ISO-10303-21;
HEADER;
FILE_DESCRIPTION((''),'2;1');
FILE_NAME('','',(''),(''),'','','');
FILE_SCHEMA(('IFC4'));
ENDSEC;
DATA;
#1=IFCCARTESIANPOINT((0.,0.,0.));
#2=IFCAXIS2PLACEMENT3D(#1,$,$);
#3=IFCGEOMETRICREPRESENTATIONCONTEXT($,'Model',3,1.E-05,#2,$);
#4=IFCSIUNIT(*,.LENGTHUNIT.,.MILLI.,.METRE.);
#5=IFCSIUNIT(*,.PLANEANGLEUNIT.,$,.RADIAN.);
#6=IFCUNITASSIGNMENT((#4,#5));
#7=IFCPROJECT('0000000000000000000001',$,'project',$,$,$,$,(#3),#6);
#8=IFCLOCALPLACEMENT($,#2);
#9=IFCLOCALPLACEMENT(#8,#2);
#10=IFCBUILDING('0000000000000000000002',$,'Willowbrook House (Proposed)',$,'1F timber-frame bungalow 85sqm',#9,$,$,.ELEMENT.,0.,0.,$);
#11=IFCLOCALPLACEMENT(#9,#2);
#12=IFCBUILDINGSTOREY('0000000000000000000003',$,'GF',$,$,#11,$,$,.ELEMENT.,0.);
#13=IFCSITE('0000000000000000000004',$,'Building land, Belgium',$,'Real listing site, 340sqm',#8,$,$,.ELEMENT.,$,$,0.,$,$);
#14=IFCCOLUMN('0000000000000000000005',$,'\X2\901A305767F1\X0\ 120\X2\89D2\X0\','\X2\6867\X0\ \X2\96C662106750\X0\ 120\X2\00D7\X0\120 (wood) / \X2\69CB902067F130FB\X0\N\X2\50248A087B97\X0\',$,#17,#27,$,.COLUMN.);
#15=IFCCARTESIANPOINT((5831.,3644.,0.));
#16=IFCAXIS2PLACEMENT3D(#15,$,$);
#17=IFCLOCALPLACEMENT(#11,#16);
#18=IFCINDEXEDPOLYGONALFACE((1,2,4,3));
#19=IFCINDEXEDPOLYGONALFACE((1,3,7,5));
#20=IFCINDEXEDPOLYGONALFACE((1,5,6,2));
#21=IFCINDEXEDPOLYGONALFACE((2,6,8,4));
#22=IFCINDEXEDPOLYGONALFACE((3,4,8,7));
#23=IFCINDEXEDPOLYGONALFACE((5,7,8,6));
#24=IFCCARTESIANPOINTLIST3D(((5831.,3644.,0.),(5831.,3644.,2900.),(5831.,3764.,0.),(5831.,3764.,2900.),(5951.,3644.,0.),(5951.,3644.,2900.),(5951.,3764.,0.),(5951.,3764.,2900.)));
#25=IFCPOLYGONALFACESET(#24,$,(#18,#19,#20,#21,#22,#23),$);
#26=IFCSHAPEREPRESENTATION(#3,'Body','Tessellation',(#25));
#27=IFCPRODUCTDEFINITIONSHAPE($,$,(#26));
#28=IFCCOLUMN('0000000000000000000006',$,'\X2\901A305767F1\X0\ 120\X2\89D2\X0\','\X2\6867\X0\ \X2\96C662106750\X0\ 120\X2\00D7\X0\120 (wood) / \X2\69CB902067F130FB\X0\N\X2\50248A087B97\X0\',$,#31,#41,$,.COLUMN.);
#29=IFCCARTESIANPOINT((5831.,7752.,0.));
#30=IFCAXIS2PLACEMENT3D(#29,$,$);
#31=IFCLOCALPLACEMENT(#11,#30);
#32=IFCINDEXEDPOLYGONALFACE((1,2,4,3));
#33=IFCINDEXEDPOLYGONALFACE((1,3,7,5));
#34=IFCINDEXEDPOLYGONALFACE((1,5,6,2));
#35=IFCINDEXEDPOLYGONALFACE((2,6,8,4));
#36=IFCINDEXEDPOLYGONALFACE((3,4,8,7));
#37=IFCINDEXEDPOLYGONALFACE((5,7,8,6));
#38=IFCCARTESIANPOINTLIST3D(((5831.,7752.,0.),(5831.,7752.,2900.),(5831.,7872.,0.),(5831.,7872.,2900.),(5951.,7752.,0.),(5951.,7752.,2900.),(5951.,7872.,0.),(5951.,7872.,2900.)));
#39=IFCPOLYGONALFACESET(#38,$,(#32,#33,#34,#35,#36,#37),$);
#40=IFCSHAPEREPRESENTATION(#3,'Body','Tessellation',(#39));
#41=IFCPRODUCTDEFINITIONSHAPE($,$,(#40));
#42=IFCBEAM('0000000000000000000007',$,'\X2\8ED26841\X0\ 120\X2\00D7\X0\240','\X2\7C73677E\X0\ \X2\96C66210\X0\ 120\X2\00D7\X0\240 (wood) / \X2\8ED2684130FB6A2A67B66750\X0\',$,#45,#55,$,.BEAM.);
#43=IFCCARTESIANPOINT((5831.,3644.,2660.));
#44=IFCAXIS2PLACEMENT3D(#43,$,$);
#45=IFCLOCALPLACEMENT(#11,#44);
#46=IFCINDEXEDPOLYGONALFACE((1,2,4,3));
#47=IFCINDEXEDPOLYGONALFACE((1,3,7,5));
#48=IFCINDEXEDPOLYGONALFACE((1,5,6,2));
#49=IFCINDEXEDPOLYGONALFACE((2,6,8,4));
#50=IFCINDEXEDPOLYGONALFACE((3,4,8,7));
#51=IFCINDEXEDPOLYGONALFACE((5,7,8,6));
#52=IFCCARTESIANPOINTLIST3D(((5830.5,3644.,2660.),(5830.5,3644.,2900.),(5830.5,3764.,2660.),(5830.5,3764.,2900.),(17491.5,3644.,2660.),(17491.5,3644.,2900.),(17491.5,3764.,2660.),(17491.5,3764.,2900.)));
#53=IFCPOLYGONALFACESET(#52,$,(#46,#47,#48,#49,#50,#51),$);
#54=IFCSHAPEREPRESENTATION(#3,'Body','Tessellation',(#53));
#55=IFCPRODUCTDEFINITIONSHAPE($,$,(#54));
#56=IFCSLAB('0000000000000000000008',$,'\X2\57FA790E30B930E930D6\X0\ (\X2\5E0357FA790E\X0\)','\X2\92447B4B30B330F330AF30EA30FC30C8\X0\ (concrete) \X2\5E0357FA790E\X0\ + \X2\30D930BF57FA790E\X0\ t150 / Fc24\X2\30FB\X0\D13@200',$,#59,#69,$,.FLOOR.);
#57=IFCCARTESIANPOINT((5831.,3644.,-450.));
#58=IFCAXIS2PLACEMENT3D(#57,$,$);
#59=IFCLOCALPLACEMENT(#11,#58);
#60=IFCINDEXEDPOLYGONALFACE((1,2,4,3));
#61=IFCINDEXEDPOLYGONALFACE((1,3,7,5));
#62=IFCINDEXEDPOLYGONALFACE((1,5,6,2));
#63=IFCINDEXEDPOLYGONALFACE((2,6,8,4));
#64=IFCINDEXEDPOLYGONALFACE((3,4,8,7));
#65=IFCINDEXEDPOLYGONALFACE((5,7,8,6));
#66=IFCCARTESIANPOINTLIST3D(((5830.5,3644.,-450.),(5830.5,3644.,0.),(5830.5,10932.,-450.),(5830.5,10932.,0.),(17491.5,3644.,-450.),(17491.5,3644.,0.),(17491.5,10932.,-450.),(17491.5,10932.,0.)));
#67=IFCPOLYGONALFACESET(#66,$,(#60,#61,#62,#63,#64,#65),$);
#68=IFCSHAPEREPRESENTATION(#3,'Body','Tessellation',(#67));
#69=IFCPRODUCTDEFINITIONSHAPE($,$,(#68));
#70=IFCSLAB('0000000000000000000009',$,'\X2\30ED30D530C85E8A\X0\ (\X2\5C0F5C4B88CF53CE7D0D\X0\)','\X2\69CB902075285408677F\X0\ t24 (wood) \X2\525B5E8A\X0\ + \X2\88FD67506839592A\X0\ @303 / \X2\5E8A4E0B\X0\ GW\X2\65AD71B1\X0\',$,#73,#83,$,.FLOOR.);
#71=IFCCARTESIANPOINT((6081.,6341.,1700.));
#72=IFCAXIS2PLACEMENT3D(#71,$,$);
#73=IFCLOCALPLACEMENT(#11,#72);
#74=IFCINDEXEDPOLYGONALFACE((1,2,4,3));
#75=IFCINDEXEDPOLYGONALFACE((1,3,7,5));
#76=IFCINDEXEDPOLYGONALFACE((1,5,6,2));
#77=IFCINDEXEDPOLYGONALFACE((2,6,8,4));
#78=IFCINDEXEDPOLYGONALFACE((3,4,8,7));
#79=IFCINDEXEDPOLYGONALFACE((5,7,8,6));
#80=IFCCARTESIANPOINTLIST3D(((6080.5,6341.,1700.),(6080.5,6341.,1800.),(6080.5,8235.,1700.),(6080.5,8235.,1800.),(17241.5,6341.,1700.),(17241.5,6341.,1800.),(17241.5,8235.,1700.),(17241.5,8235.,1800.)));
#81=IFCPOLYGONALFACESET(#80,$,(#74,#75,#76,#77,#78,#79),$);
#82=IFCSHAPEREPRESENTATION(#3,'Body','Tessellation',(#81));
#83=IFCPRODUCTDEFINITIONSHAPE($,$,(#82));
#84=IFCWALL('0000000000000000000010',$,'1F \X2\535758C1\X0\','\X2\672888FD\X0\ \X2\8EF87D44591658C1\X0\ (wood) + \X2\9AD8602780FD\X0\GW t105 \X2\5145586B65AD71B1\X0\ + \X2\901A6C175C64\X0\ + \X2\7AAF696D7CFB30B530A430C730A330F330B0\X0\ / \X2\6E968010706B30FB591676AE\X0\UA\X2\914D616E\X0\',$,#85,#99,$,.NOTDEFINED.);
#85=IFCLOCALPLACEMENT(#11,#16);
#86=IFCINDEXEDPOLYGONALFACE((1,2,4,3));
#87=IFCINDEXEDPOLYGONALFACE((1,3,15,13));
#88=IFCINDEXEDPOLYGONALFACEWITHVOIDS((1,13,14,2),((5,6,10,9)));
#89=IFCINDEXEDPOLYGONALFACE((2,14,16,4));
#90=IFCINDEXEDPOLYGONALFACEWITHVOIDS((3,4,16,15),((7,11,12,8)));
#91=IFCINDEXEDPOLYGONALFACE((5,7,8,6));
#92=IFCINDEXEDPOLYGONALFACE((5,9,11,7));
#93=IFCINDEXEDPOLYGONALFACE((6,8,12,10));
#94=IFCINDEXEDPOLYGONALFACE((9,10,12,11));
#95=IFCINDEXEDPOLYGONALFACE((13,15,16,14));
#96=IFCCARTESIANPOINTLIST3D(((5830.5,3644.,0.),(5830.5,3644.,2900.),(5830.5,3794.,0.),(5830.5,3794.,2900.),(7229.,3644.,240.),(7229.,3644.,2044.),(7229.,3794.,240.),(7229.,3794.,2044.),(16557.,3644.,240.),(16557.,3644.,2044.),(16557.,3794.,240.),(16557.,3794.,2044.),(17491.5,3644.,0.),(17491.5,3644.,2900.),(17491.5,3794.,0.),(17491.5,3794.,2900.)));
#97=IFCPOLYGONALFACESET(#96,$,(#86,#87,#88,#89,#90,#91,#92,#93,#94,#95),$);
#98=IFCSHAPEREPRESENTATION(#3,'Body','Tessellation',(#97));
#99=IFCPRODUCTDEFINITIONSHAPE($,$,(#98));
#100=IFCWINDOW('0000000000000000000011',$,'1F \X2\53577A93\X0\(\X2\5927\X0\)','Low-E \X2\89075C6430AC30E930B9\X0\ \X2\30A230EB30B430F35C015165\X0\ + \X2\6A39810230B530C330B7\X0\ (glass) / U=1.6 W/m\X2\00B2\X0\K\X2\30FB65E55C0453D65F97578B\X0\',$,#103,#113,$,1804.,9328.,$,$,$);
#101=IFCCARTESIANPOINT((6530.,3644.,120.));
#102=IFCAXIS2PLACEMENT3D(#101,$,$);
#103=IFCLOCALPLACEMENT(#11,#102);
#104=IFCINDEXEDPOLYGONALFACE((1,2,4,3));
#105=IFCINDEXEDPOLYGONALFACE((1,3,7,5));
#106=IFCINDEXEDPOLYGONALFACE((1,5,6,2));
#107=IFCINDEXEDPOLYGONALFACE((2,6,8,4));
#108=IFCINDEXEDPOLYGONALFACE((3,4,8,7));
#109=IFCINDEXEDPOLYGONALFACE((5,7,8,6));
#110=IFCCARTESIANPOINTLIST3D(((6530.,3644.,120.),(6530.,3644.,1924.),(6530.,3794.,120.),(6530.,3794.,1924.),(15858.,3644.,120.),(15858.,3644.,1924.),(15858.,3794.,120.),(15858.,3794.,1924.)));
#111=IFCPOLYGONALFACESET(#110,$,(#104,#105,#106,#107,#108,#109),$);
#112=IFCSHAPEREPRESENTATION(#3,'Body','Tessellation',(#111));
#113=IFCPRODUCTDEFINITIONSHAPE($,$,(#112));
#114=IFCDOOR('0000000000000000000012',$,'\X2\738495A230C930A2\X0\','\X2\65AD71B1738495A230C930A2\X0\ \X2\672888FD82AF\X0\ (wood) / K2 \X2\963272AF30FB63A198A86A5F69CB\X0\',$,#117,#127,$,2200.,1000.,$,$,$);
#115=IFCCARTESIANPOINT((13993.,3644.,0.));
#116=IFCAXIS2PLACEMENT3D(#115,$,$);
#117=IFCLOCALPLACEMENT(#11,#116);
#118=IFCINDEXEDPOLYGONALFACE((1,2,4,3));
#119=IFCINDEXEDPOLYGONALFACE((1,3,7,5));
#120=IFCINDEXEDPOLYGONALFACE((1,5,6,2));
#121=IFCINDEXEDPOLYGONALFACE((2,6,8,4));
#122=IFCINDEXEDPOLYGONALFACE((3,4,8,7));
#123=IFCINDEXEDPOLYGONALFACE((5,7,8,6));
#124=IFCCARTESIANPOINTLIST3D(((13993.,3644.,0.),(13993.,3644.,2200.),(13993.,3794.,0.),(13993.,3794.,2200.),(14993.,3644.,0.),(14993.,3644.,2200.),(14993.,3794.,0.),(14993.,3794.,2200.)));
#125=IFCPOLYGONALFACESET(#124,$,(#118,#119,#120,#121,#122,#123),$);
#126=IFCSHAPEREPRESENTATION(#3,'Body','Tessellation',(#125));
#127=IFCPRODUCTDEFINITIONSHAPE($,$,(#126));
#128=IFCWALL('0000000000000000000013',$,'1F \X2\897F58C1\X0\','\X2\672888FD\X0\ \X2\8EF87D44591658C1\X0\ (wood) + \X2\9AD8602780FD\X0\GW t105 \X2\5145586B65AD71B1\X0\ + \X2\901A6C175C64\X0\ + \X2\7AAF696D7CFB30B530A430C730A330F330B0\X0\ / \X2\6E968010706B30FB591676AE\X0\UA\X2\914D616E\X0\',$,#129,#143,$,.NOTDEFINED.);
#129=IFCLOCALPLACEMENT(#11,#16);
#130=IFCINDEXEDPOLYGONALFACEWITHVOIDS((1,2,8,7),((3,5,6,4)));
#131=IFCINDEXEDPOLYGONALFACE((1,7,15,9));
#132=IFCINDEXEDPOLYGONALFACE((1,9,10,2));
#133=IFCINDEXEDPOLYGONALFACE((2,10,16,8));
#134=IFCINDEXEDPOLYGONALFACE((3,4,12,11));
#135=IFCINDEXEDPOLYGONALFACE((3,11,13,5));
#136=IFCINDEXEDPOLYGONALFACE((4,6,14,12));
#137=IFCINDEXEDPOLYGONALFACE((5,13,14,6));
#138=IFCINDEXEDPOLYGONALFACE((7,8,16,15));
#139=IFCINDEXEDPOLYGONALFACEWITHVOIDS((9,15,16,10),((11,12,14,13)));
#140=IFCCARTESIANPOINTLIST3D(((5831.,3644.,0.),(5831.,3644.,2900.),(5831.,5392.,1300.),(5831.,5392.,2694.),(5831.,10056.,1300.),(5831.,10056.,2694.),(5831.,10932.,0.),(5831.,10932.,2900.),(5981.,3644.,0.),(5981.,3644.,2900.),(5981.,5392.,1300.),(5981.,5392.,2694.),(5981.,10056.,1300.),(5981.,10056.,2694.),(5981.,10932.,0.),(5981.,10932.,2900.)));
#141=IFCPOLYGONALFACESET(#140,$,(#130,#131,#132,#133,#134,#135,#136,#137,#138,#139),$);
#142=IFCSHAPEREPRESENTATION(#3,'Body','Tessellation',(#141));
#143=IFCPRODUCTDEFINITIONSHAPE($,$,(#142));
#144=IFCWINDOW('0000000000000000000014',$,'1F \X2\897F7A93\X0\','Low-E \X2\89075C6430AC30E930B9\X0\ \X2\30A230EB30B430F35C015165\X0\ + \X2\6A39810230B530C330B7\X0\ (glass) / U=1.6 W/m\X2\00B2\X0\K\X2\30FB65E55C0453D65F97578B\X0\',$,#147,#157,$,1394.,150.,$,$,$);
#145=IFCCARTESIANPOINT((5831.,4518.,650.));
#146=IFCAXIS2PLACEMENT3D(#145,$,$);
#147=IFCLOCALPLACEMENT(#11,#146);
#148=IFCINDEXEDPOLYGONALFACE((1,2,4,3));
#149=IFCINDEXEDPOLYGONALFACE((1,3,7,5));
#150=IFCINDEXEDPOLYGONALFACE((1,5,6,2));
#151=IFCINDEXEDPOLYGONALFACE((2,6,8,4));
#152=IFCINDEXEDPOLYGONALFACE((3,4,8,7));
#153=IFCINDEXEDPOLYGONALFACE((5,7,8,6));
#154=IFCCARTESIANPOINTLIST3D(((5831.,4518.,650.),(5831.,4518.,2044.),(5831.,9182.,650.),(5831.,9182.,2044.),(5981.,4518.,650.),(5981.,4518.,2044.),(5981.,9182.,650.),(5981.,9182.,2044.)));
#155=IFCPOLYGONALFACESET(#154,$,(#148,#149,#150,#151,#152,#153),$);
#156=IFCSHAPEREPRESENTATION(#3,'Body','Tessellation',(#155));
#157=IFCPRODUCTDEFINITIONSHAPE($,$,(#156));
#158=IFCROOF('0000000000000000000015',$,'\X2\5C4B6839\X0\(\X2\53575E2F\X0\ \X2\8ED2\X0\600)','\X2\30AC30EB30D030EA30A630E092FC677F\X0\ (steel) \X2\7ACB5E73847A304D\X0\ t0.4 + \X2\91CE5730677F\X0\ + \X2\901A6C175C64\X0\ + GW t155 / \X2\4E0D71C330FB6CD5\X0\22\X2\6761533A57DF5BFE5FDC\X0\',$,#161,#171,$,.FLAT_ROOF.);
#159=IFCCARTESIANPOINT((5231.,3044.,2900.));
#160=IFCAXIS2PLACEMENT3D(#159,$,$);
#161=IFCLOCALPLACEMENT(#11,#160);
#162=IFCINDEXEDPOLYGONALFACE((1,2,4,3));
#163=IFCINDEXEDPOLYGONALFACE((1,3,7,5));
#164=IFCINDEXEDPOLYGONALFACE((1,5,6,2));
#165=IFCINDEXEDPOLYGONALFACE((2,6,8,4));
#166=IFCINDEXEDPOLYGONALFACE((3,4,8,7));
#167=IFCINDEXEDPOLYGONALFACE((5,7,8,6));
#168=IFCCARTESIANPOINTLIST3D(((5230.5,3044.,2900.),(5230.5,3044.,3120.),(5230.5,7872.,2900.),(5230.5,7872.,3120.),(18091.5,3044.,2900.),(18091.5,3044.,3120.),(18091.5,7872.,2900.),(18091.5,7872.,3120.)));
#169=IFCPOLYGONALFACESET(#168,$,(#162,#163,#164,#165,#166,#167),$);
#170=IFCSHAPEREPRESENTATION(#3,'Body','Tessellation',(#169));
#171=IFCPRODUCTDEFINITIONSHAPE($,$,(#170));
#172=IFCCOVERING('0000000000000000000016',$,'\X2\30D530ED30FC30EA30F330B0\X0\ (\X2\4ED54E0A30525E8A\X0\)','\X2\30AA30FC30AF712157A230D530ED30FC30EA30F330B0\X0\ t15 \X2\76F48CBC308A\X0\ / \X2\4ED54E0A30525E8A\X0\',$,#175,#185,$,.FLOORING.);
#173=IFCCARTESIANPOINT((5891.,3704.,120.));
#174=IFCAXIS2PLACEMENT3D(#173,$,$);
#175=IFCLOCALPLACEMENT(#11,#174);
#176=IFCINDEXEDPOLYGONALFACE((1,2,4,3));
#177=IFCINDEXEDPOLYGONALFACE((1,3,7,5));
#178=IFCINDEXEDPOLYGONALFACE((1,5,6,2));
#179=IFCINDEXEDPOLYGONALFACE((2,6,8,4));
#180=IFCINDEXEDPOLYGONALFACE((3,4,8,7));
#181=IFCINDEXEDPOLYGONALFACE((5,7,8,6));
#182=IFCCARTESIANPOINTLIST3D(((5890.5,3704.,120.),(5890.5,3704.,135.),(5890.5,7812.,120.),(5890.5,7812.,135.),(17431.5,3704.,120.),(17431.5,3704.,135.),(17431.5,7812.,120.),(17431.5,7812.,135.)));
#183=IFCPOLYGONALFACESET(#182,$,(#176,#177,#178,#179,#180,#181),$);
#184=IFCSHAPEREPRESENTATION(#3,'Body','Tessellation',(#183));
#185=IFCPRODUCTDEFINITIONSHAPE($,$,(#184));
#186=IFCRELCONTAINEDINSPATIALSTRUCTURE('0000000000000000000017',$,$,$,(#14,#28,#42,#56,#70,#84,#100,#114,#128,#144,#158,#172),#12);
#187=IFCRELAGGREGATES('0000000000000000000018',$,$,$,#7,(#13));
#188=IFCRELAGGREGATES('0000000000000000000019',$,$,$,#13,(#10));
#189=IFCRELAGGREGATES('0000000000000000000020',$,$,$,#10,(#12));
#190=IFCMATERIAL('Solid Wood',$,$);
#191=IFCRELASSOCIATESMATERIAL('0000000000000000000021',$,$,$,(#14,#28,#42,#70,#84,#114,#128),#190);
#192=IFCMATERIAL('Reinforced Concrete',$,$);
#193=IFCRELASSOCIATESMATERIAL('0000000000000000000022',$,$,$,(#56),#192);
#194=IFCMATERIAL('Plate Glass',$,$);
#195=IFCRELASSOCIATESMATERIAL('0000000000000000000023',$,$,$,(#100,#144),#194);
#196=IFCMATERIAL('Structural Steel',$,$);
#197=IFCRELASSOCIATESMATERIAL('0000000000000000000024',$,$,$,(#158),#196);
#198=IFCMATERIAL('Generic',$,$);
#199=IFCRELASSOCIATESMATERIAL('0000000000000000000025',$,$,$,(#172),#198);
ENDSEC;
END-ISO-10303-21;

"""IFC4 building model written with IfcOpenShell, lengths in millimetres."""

from ifc_helpers import new_model, si_unit, frame, frame_2d, origin, place, context, project, spatial, rectangle, extrude, material, element, fill, save


model = new_model("IFC4")

# Units and contexts
model_context = context("Model", 3, precision=1e-05, world=origin())
ifc_project = project(units=[si_unit("LENGTHUNIT", "METRE", prefix="MILLI"), si_unit("PLANEANGLEUNIT", "RADIAN")], contexts=[model_context])

# Site, building, storey
site_placement = place(None, origin())
site = spatial("IfcSite", under=ifc_project, at=site_placement, Name="Building land, Belgium", ObjectType="Real listing site, 340sqm", CompositionType="ELEMENT", RefElevation=0.0)
building_placement = place(site_placement, origin())
building = spatial("IfcBuilding", under=site, at=building_placement, Name="Willowbrook House (Proposed)", ObjectType="1F timber-frame bungalow 85sqm", CompositionType="ELEMENT", ElevationOfRefHeight=0.0, ElevationOfTerrain=0.0)
storey_placement = place(building_placement, origin())
storey = spatial("IfcBuildingStorey", under=building, at=storey_placement, Name="GF", CompositionType="ELEMENT", Elevation=0.0)

# Columns
ifc_material_1 = material(Name="Solid Wood")
column_1_placement = place(storey_placement, frame((5831.0, 3644.0, 0.0)))
element("IfcColumn", 1, at=column_1_placement, inside=storey, material=ifc_material_1, Name="通し柱 120角", Description="桧 集成材 120×120 (wood) / 構造柱・N値計算", PredefinedType="COLUMN", context=model_context, shape_type="SweptSolid", body=[
    extrude(rectangle(XDim=120.0, YDim=120.0, at=frame_2d((60.0, 60.0))), frame((5831.0, 3644.0, 0.0)), (0.0, 0.0, 1.0), 2900.0),
])
column_2_placement = place(storey_placement, frame((5831.0, 7752.0, 0.0)))
element("IfcColumn", 2, at=column_2_placement, inside=storey, material=ifc_material_1, Name="通し柱 120角", Description="桧 集成材 120×120 (wood) / 構造柱・N値計算", PredefinedType="COLUMN", context=model_context, shape_type="SweptSolid", body=[
    extrude(rectangle(XDim=120.0, YDim=120.0, at=frame_2d((60.0, 60.0))), frame((5831.0, 7752.0, 0.0)), (0.0, 0.0, 1.0), 2900.0),
])

# Beam
beam_1_placement = place(storey_placement, frame((5831.0, 3644.0, 2660.0)))
element("IfcBeam", 3, at=beam_1_placement, inside=storey, material=ifc_material_1, Name="軒桁 120×240", Description="米松 集成 120×240 (wood) / 軒桁・横架材", PredefinedType="BEAM", context=model_context, shape_type="SweptSolid", body=[
    extrude(rectangle(XDim=11661.0, YDim=120.0, at=frame_2d((5830.0, 60.0))), frame((5831.0, 3644.0, 2660.0)), (0.0, 0.0, 1.0), 240.0),
])

# Slabs
ifc_material_2 = material(Name="Reinforced Concrete")
slab_1_placement = place(storey_placement, frame((5831.0, 3644.0, -450.0)))
element("IfcSlab", 4, at=slab_1_placement, inside=storey, material=ifc_material_2, Name="基礎スラブ (布基礎)", Description="鉄筋コンクリート (concrete) 布基礎 + ベタ基礎 t150 / Fc24・D13@200", PredefinedType="FLOOR", context=model_context, shape_type="SweptSolid", body=[
    extrude(rectangle(XDim=11661.0, YDim=7288.0, at=frame_2d((5830.0, 3644.0))), frame((5831.0, 3644.0, -450.0)), (0.0, 0.0, 1.0), 450.0),
])
slab_2_placement = place(storey_placement, frame((6081.0, 6341.0, 1700.0)))
element("IfcSlab", 5, at=slab_2_placement, inside=storey, material=ifc_material_1, Name="ロフト床 (小屋裏収納)", Description="構造用合板 t24 (wood) 剛床 + 製材根太 @303 / 床下 GW断熱", PredefinedType="FLOOR", context=model_context, shape_type="SweptSolid", body=[
    extrude(rectangle(XDim=11161.0, YDim=1894.0, at=frame_2d((5580.0, 947.0))), frame((6081.0, 6341.0, 1700.0)), (0.0, 0.0, 1.0), 100.0),
])

# Wall, openings, window, door
wall_1_placement = place(storey_placement, frame((5831.0, 3644.0, 0.0)))
wall_1 = element("IfcWall", 6, at=wall_1_placement, inside=storey, material=ifc_material_1, Name="1F 南壁", Description="木製 軸組外壁 (wood) + 高性能GW t105 充填断熱 + 通気層 + 窯業系サイディング / 準耐火・外皮UA配慮", PredefinedType="NOTDEFINED", context=model_context, shape_type="SweptSolid", body=[
    extrude(rectangle(XDim=11661.0, YDim=150.0, at=frame_2d((5830.0, 75.0))), frame((5831.0, 3644.0, 0.0)), (0.0, 0.0, 1.0), 2900.0),
])
opening_1_placement = place(storey_placement, frame((6530.0, 3644.0, 120.0)))
opening_1 = element("IfcOpeningElement", 7, at=opening_1_placement, cuts=wall_1, PredefinedType="NOTDEFINED", context=model_context, shape_type="SweptSolid", body=[
    extrude(rectangle(XDim=9328.0, YDim=150.0, at=frame_2d((4664.0, 75.0))), frame((6530.0, 3644.0, 120.0)), (0.0, 0.0, 1.0), 1804.0),
])
opening_2_placement = place(storey_placement, frame((13993.0, 3644.0, 0.0)))
opening_2 = element("IfcOpeningElement", 8, at=opening_2_placement, cuts=wall_1, PredefinedType="NOTDEFINED", context=model_context, shape_type="SweptSolid", body=[
    extrude(rectangle(XDim=1000.0, YDim=150.0, at=frame_2d((500.0, 75.0))), frame((13993.0, 3644.0, 0.0)), (0.0, 0.0, 1.0), 2200.0),
])
ifc_material_3 = material(Name="Plate Glass")
window_1_placement = place(storey_placement, frame((6530.0, 3644.0, 120.0)))
window_1 = element("IfcWindow", 9, at=window_1_placement, inside=storey, material=ifc_material_3, Name="1F 南窓(大)", Description="Low-E 複層ガラス アルゴン封入 + 樹脂サッシ (glass) / U=1.6 W/m²K・日射取得型", OverallHeight=1804.0, OverallWidth=9328.0, context=model_context, shape_type="SweptSolid", body=[
    extrude(rectangle(XDim=9328.0, YDim=150.0, at=frame_2d((4664.0, 75.0))), frame((6530.0, 3644.0, 120.0)), (0.0, 0.0, 1.0), 1804.0),
])
fill(opening_1, window_1)
door_placement = place(storey_placement, frame((13993.0, 3644.0, 0.0)))
door = element("IfcDoor", 10, at=door_placement, inside=storey, material=ifc_material_1, Name="玄関ドア", Description="断熱玄関ドア 木製芯 (wood) / K2 防犯・採風機構", OverallHeight=2200.0, OverallWidth=1000.0, context=model_context, shape_type="SweptSolid", body=[
    extrude(rectangle(XDim=1000.0, YDim=150.0, at=frame_2d((500.0, 75.0))), frame((13993.0, 3644.0, 0.0)), (0.0, 0.0, 1.0), 2200.0),
])
fill(opening_2, door)

# Wall, opening, window
wall_2_placement = place(storey_placement, frame((5831.0, 3644.0, 0.0)))
wall_2 = element("IfcWall", 11, at=wall_2_placement, inside=storey, material=ifc_material_1, Name="1F 西壁", Description="木製 軸組外壁 (wood) + 高性能GW t105 充填断熱 + 通気層 + 窯業系サイディング / 準耐火・外皮UA配慮", PredefinedType="NOTDEFINED", context=model_context, shape_type="SweptSolid", body=[
    extrude(rectangle(XDim=150.0, YDim=7288.0, at=frame_2d((75.0, 3644.0))), frame((5831.0, 3644.0, 0.0)), (0.0, 0.0, 1.0), 2900.0),
])
opening_3_placement = place(storey_placement, frame((5831.0, 4518.0, 650.0)))
opening_3 = element("IfcOpeningElement", 12, at=opening_3_placement, cuts=wall_2, PredefinedType="NOTDEFINED", context=model_context, shape_type="SweptSolid", body=[
    extrude(rectangle(XDim=150.0, YDim=4664.0, at=frame_2d((75.0, 2332.0))), frame((5831.0, 4518.0, 650.0)), (0.0, 0.0, 1.0), 1394.0),
])
window_2_placement = place(storey_placement, frame((5831.0, 4518.0, 650.0)))
window_2 = element("IfcWindow", 13, at=window_2_placement, inside=storey, material=ifc_material_3, Name="1F 西窓", Description="Low-E 複層ガラス アルゴン封入 + 樹脂サッシ (glass) / U=1.6 W/m²K・日射取得型", OverallHeight=1394.0, OverallWidth=150.0, context=model_context, shape_type="SweptSolid", body=[
    extrude(rectangle(XDim=150.0, YDim=4664.0, at=frame_2d((75.0, 2332.0))), frame((5831.0, 4518.0, 650.0)), (0.0, 0.0, 1.0), 1394.0),
])
fill(opening_3, window_2)

# Roof
ifc_material_4 = material(Name="Structural Steel")
roof_placement = place(storey_placement, frame((5231.0, 3044.0, 2900.0)))
element("IfcRoof", 14, at=roof_placement, inside=storey, material=ifc_material_4, Name="屋根(南帯 軒600)", Description="ガルバリウム鋼板 (steel) 立平葺き t0.4 + 野地板 + 通気層 + GW t155 / 不燃・法22条区域対応", PredefinedType="FLAT_ROOF", context=model_context, shape_type="SweptSolid", body=[
    extrude(rectangle(XDim=12861.0, YDim=4828.0, at=frame_2d((6430.0, 2414.0))), frame((5231.0, 3044.0, 2900.0)), (0.0, 0.0, 1.0), 220.0),
])

# Covering
ifc_material_5 = material(Name="Generic")
covering_1_placement = place(storey_placement, frame((5891.0, 3704.0, 120.0)))
element("IfcCovering", 15, at=covering_1_placement, inside=storey, material=ifc_material_5, Name="フローリング (仕上げ床)", Description="オーク無垢フローリング t15 直貼り / 仕上げ床", PredefinedType="FLOORING", context=model_context, shape_type="SweptSolid", body=[
    extrude(rectangle(XDim=11541.0, YDim=4108.0, at=frame_2d((5770.0, 2054.0))), frame((5891.0, 3704.0, 120.0)), (0.0, 0.0, 1.0), 15.0),
])

save(model, "model.ifc")
